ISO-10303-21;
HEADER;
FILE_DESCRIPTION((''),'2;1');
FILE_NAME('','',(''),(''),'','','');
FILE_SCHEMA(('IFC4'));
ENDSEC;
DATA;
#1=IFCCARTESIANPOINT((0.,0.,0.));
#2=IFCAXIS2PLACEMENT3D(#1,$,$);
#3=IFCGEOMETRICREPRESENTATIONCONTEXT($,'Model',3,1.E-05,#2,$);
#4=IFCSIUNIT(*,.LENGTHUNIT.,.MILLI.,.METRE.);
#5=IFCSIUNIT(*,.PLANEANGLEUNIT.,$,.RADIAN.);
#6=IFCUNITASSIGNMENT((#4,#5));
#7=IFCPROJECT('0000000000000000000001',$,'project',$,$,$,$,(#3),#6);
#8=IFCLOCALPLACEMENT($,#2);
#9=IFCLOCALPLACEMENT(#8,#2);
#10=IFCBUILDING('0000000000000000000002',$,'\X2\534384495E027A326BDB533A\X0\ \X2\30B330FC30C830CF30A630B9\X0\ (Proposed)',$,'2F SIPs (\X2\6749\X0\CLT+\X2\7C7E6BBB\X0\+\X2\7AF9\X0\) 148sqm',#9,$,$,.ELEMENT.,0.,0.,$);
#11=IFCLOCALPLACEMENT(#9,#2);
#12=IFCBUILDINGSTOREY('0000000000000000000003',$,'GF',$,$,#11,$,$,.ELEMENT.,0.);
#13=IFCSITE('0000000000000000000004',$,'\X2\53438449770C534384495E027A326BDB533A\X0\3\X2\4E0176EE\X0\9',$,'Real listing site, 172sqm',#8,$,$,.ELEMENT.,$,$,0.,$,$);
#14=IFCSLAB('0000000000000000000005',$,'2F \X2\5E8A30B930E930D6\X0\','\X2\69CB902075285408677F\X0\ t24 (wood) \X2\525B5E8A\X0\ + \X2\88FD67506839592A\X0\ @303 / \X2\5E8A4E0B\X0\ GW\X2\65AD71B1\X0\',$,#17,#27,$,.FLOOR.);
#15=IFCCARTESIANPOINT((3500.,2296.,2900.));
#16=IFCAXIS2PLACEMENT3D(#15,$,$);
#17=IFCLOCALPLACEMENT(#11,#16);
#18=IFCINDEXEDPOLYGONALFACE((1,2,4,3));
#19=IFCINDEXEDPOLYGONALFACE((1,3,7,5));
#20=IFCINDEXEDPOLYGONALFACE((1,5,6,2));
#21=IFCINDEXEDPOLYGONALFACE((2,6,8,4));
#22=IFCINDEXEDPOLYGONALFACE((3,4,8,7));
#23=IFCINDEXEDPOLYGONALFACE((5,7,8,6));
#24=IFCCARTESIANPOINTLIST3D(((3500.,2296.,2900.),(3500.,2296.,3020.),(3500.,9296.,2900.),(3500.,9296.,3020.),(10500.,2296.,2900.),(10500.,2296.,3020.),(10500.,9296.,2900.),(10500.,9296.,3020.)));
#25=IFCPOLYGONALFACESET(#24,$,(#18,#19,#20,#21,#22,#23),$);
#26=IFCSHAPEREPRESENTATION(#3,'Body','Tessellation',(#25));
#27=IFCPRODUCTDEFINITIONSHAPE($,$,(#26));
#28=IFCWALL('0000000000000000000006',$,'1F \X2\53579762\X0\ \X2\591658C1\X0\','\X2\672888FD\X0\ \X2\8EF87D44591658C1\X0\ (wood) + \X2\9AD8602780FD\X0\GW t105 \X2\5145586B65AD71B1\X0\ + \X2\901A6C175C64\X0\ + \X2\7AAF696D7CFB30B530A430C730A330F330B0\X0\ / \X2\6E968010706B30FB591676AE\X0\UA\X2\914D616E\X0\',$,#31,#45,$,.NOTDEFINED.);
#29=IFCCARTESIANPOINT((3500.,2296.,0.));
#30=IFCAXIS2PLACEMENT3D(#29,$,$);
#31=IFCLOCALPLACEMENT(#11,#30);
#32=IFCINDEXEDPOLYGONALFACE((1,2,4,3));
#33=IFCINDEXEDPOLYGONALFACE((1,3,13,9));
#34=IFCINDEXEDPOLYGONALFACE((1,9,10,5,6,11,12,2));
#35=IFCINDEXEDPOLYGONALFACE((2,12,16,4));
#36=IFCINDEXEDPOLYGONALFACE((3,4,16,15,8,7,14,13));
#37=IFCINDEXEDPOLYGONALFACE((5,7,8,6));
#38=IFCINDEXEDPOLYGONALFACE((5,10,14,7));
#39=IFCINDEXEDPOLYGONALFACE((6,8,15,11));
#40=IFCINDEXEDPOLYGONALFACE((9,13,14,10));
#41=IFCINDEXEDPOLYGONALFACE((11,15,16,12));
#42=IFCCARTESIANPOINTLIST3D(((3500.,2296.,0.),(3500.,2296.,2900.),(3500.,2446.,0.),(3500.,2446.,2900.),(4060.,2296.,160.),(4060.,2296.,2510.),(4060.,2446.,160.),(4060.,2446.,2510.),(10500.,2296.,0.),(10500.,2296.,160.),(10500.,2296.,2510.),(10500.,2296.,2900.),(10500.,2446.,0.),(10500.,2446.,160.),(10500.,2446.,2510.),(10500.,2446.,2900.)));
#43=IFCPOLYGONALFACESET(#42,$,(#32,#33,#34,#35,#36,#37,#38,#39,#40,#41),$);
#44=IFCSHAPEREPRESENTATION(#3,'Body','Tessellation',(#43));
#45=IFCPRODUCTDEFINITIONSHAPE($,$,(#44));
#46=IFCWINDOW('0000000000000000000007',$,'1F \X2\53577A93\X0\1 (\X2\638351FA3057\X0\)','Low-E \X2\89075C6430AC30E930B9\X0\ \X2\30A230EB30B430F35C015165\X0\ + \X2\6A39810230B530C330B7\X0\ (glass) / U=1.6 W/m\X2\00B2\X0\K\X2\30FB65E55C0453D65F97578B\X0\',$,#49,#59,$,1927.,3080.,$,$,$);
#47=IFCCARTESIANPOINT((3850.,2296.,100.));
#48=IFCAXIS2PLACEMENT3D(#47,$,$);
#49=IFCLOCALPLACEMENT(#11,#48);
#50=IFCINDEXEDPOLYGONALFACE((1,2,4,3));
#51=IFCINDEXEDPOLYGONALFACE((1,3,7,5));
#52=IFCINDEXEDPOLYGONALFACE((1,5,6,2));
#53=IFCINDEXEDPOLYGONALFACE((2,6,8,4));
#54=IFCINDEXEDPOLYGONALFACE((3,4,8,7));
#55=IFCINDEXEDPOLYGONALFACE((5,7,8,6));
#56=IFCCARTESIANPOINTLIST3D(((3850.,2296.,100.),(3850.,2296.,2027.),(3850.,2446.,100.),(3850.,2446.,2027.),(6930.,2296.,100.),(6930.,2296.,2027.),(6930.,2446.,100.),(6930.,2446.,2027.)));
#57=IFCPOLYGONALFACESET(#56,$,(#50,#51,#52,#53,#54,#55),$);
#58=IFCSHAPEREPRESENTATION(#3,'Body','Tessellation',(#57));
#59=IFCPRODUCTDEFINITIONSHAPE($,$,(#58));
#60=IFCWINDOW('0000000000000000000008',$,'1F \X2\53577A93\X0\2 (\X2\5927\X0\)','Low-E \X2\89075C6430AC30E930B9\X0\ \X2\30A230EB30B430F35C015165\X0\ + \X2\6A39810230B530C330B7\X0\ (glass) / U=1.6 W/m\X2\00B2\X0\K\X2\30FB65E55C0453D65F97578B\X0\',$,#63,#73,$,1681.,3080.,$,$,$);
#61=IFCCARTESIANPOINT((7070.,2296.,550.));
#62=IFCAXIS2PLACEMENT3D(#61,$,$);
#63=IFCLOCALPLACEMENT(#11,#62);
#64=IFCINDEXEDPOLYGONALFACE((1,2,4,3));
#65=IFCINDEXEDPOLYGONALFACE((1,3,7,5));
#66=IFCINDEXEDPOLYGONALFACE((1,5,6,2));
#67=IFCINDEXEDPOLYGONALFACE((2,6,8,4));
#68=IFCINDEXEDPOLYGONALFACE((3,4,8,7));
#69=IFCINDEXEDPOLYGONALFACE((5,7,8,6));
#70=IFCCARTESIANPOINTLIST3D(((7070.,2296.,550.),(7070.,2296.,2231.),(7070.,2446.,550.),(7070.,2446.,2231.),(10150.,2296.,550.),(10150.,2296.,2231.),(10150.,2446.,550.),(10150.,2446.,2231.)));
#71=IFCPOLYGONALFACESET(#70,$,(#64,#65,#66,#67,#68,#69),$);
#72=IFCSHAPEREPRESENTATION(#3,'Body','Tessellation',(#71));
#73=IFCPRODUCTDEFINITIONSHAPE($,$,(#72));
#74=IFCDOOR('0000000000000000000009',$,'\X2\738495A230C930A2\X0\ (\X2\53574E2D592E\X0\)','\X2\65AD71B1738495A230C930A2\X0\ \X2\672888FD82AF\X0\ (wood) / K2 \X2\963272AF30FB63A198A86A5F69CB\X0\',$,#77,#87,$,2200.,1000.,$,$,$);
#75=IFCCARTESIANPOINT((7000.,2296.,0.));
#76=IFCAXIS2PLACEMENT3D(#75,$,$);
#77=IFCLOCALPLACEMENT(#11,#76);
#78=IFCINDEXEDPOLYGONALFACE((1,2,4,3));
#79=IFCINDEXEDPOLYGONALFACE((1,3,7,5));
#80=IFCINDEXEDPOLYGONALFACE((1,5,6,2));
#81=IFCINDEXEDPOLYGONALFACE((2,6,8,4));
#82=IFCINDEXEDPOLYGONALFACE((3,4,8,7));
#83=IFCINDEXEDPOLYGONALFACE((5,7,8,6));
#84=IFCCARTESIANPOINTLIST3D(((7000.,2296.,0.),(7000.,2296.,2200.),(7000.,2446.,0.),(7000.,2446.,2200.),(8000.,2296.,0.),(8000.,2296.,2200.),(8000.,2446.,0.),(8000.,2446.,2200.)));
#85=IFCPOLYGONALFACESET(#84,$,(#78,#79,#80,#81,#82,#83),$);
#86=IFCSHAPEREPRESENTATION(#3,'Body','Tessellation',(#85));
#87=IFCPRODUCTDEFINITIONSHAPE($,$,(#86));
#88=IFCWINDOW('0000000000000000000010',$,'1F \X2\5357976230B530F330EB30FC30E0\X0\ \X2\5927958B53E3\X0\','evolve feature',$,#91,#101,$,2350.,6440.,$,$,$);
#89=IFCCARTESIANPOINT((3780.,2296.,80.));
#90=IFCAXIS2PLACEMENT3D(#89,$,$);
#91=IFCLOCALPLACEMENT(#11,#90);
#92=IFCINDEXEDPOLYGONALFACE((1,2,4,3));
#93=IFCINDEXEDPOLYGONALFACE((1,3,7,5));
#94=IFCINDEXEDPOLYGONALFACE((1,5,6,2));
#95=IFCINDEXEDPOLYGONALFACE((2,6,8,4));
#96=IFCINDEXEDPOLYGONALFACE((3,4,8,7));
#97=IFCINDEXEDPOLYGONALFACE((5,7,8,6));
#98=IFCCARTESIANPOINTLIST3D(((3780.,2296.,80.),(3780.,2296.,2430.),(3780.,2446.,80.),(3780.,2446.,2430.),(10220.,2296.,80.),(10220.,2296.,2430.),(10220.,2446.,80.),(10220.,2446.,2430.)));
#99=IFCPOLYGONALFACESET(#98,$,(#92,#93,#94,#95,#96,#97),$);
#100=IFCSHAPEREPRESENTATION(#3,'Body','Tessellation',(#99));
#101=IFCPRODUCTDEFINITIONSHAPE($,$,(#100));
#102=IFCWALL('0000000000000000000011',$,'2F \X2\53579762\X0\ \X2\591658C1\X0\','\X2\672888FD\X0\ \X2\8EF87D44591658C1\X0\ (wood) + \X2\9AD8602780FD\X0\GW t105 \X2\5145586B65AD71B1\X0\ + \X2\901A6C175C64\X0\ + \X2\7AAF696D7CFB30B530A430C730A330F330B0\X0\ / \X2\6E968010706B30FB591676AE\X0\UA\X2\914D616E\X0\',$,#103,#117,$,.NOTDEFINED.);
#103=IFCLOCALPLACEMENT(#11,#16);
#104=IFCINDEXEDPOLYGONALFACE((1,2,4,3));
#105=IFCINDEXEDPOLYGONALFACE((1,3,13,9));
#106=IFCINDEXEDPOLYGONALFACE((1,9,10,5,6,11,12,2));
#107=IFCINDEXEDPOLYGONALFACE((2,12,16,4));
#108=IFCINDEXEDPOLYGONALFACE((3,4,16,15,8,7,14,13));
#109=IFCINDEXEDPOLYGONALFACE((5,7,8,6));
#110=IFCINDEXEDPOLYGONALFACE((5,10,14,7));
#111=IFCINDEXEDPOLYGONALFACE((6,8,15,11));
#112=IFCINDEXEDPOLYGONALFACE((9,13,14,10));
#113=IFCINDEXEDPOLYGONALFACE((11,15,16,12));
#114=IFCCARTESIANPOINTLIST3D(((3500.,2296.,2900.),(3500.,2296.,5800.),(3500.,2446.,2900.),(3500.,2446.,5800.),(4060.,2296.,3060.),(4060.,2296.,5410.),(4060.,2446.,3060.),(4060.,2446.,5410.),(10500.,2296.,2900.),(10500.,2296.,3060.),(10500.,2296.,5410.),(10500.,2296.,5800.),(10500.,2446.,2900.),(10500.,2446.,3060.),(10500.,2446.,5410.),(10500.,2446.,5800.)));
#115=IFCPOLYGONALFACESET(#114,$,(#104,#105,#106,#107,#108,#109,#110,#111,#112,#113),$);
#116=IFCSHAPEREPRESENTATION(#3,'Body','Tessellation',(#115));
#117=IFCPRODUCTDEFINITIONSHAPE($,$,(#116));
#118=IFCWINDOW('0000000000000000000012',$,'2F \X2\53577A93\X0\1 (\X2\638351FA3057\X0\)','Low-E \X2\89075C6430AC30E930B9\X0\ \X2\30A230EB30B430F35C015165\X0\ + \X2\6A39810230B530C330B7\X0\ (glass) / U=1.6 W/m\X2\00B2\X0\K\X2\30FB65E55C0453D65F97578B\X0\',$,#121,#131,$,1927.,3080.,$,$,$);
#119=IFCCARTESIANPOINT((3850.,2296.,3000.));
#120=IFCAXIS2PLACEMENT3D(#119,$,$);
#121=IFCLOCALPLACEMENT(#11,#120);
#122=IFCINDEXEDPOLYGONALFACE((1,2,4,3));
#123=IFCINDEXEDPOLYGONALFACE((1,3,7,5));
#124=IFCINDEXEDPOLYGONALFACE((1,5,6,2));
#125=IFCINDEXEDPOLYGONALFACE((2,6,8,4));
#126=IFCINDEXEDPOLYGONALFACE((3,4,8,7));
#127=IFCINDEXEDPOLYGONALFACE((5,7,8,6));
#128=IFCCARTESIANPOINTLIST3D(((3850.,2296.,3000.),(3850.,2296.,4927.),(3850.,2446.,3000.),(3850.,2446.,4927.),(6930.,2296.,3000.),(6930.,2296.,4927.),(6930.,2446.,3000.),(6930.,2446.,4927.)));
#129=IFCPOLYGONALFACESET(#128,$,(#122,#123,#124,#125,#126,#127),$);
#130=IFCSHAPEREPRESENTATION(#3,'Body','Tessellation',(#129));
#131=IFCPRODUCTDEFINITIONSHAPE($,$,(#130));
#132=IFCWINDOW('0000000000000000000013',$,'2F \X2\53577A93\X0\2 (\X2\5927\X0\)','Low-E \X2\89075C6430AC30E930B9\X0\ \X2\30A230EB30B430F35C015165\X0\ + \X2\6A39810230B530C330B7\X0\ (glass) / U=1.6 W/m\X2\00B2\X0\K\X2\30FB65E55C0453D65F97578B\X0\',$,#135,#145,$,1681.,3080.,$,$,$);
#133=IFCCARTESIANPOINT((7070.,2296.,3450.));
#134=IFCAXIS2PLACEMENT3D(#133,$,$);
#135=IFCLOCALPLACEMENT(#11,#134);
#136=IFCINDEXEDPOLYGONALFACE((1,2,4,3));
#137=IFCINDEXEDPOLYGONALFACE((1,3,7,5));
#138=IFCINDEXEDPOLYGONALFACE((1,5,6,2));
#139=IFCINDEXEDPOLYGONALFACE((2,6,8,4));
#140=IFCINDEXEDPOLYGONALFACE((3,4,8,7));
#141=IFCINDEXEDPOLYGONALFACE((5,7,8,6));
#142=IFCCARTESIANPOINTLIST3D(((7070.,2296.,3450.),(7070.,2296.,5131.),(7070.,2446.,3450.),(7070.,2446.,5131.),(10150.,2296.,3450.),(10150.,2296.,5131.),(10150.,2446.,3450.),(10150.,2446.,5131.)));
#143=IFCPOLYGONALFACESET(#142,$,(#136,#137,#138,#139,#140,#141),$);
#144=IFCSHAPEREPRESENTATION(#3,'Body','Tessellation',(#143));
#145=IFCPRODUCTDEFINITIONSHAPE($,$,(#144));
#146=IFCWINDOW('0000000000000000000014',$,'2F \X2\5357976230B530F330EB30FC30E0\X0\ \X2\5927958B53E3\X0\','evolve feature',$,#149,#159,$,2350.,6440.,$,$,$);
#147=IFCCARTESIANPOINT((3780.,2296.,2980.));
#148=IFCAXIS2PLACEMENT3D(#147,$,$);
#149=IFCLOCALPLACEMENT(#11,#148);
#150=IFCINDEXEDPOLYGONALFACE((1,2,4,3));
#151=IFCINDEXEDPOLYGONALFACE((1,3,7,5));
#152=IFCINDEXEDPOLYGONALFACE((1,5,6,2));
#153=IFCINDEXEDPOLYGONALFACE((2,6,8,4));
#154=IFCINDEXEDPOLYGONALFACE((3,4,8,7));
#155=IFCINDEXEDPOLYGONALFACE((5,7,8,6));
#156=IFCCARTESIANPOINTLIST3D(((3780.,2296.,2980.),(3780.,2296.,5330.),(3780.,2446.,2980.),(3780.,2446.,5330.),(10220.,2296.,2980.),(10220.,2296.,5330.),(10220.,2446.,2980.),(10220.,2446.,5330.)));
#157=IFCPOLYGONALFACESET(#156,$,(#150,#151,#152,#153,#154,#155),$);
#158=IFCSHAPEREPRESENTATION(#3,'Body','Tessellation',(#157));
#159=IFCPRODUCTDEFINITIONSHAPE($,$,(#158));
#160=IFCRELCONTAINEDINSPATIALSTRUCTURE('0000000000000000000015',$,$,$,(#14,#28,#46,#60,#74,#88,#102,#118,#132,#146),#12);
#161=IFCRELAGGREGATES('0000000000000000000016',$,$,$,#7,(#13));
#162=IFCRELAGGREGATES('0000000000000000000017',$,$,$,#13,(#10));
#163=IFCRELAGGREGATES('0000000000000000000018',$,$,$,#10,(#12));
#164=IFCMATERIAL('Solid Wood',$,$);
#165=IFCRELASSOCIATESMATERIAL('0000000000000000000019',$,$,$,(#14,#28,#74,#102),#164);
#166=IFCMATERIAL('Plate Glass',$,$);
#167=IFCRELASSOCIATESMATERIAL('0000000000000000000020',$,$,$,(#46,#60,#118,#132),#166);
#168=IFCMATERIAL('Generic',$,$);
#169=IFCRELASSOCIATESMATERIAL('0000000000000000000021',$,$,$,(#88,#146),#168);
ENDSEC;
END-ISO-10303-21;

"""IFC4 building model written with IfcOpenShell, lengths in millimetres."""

from ifc_helpers import new_model, si_unit, frame, frame_2d, origin, place, context, project, spatial, rectangle, extrude, material, element, fill, save


model = new_model("IFC4")

# Units and contexts
model_context = context("Model", 3, precision=1e-05, world=origin())
ifc_project = project(units=[si_unit("LENGTHUNIT", "METRE", prefix="MILLI"), si_unit("PLANEANGLEUNIT", "RADIAN")], contexts=[model_context])

# Site, building, storey
site_placement = place(None, origin())
site = spatial("IfcSite", under=ifc_project, at=site_placement, Name="千葉県千葉市稲毛区3丁目9", ObjectType="Real listing site, 172sqm", CompositionType="ELEMENT", RefElevation=0.0)
building_placement = place(site_placement, origin())
building = spatial("IfcBuilding", under=site, at=building_placement, Name="千葉市稲毛区 コートハウス (Proposed)", ObjectType="2F SIPs (杉CLT+籾殻+竹) 148sqm", CompositionType="ELEMENT", ElevationOfRefHeight=0.0, ElevationOfTerrain=0.0)
storey_placement = place(building_placement, origin())
storey = spatial("IfcBuildingStorey", under=building, at=storey_placement, Name="GF", CompositionType="ELEMENT", Elevation=0.0)

# Slab
ifc_material_1 = material(Name="Solid Wood")
slab_1_placement = place(storey_placement, frame((3500.0, 2296.0, 2900.0)))
element("IfcSlab", 1, at=slab_1_placement, inside=storey, material=ifc_material_1, Name="2F 床スラブ", Description="構造用合板 t24 (wood) 剛床 + 製材根太 @303 / 床下 GW断熱", PredefinedType="FLOOR", context=model_context, shape_type="SweptSolid", body=[
    extrude(rectangle(XDim=7000.0, YDim=7000.0, at=frame_2d((3500.0, 3500.0))), frame((3500.0, 2296.0, 2900.0)), (0.0, 0.0, 1.0), 120.0),
])
ifc_material_2 = material(Name="Generic")

# Wall, openings, windows, door
wall_1_placement = place(storey_placement, frame((3500.0, 2296.0, 0.0)))
wall_1 = element("IfcWall", 2, at=wall_1_placement, inside=storey, material=ifc_material_1, Name="1F 南面 外壁", Description="木製 軸組外壁 (wood) + 高性能GW t105 充填断熱 + 通気層 + 窯業系サイディング / 準耐火・外皮UA配慮", PredefinedType="NOTDEFINED", context=model_context, shape_type="SweptSolid", body=[
    extrude(rectangle(XDim=7000.0, YDim=150.0, at=frame_2d((3500.0, 75.0))), frame((3500.0, 2296.0, 0.0)), (0.0, 0.0, 1.0), 2900.0),
])
opening_1_placement = place(storey_placement, frame((3850.0, 2296.0, 100.0)))
opening_1 = element("IfcOpeningElement", 3, at=opening_1_placement, cuts=wall_1, PredefinedType="NOTDEFINED", context=model_context, shape_type="SweptSolid", body=[
    extrude(rectangle(XDim=3080.0, YDim=150.0, at=frame_2d((1540.0, 75.0))), frame((3850.0, 2296.0, 100.0)), (0.0, 0.0, 1.0), 1927.0),
])
opening_2_placement = place(storey_placement, frame((7070.0, 2296.0, 550.0)))
opening_2 = element("IfcOpeningElement", 4, at=opening_2_placement, cuts=wall_1, PredefinedType="NOTDEFINED", context=model_context, shape_type="SweptSolid", body=[
    extrude(rectangle(XDim=3080.0, YDim=150.0, at=frame_2d((1540.0, 75.0))), frame((7070.0, 2296.0, 550.0)), (0.0, 0.0, 1.0), 1681.0),
])
opening_3_placement = place(storey_placement, frame((7000.0, 2296.0, 0.0)))
opening_3 = element("IfcOpeningElement", 5, at=opening_3_placement, cuts=wall_1, PredefinedType="NOTDEFINED", context=model_context, shape_type="SweptSolid", body=[
    extrude(rectangle(XDim=1000.0, YDim=150.0, at=frame_2d((500.0, 75.0))), frame((7000.0, 2296.0, 0.0)), (0.0, 0.0, 1.0), 2200.0),
])
opening_4_placement = place(storey_placement, frame((3780.0, 2296.0, 80.0)))
opening_4 = element("IfcOpeningElement", 6, at=opening_4_placement, cuts=wall_1, PredefinedType="NOTDEFINED", context=model_context, shape_type="SweptSolid", body=[
    extrude(rectangle(XDim=6440.0, YDim=150.0, at=frame_2d((3220.0, 75.0))), frame((3780.0, 2296.0, 80.0)), (0.0, 0.0, 1.0), 2350.0),
])
ifc_material_3 = material(Name="Plate Glass")
window_1_placement = place(storey_placement, frame((3850.0, 2296.0, 100.0)))
window_1 = element("IfcWindow", 7, at=window_1_placement, inside=storey, material=ifc_material_3, Name="1F 南窓1 (掃出し)", Description="Low-E 複層ガラス アルゴン封入 + 樹脂サッシ (glass) / U=1.6 W/m²K・日射取得型", OverallHeight=1927.0, OverallWidth=3080.0, context=model_context, shape_type="SweptSolid", body=[
    extrude(rectangle(XDim=3080.0, YDim=150.0, at=frame_2d((1540.0, 75.0))), frame((3850.0, 2296.0, 100.0)), (0.0, 0.0, 1.0), 1927.0),
])
fill(opening_1, window_1)
window_2_placement = place(storey_placement, frame((7070.0, 2296.0, 550.0)))
window_2 = element("IfcWindow", 8, at=window_2_placement, inside=storey, material=ifc_material_3, Name="1F 南窓2 (大)", Description="Low-E 複層ガラス アルゴン封入 + 樹脂サッシ (glass) / U=1.6 W/m²K・日射取得型", OverallHeight=1681.0, OverallWidth=3080.0, context=model_context, shape_type="SweptSolid", body=[
    extrude(rectangle(XDim=3080.0, YDim=150.0, at=frame_2d((1540.0, 75.0))), frame((7070.0, 2296.0, 550.0)), (0.0, 0.0, 1.0), 1681.0),
])
fill(opening_2, window_2)
door_placement = place(storey_placement, frame((7000.0, 2296.0, 0.0)))
door = element("IfcDoor", 9, at=door_placement, inside=storey, material=ifc_material_1, Name="玄関ドア (南中央)", Description="断熱玄関ドア 木製芯 (wood) / K2 防犯・採風機構", OverallHeight=2200.0, OverallWidth=1000.0, context=model_context, shape_type="SweptSolid", body=[
    extrude(rectangle(XDim=1000.0, YDim=150.0, at=frame_2d((500.0, 75.0))), frame((7000.0, 2296.0, 0.0)), (0.0, 0.0, 1.0), 2200.0),
])
fill(opening_3, door)
window_3_placement = place(storey_placement, frame((3780.0, 2296.0, 80.0)))
window_3 = element("IfcWindow", 10, at=window_3_placement, inside=storey, material=ifc_material_2, Name="1F 南面サンルーム 大開口", Description="evolve feature", OverallHeight=2350.0, OverallWidth=6440.0, context=model_context, shape_type="SweptSolid", body=[
    extrude(rectangle(XDim=6440.0, YDim=150.0, at=frame_2d((3220.0, 75.0))), frame((3780.0, 2296.0, 80.0)), (0.0, 0.0, 1.0), 2350.0),
])
fill(opening_4, window_3)

# Wall, openings, windows
wall_2_placement = place(storey_placement, frame((3500.0, 2296.0, 2900.0)))
wall_2 = element("IfcWall", 11, at=wall_2_placement, inside=storey, material=ifc_material_1, Name="2F 南面 外壁", Description="木製 軸組外壁 (wood) + 高性能GW t105 充填断熱 + 通気層 + 窯業系サイディング / 準耐火・外皮UA配慮", PredefinedType="NOTDEFINED", context=model_context, shape_type="SweptSolid", body=[
    extrude(rectangle(XDim=7000.0, YDim=150.0, at=frame_2d((3500.0, 75.0))), frame((3500.0, 2296.0, 2900.0)), (0.0, 0.0, 1.0), 2900.0),
])
opening_5_placement = place(storey_placement, frame((3850.0, 2296.0, 3000.0)))
opening_5 = element("IfcOpeningElement", 12, at=opening_5_placement, cuts=wall_2, PredefinedType="NOTDEFINED", context=model_context, shape_type="SweptSolid", body=[
    extrude(rectangle(XDim=3080.0, YDim=150.0, at=frame_2d((1540.0, 75.0))), frame((3850.0, 2296.0, 3000.0)), (0.0, 0.0, 1.0), 1927.0),
])
opening_6_placement = place(storey_placement, frame((7070.0, 2296.0, 3450.0)))
opening_6 = element("IfcOpeningElement", 13, at=opening_6_placement, cuts=wall_2, PredefinedType="NOTDEFINED", context=model_context, shape_type="SweptSolid", body=[
    extrude(rectangle(XDim=3080.0, YDim=150.0, at=frame_2d((1540.0, 75.0))), frame((7070.0, 2296.0, 3450.0)), (0.0, 0.0, 1.0), 1681.0),
])
opening_7_placement = place(storey_placement, frame((3780.0, 2296.0, 2980.0)))
opening_7 = element("IfcOpeningElement", 14, at=opening_7_placement, cuts=wall_2, PredefinedType="NOTDEFINED", context=model_context, shape_type="SweptSolid", body=[
    extrude(rectangle(XDim=6440.0, YDim=150.0, at=frame_2d((3220.0, 75.0))), frame((3780.0, 2296.0, 2980.0)), (0.0, 0.0, 1.0), 2350.0),
])
window_4_placement = place(storey_placement, frame((3850.0, 2296.0, 3000.0)))
window_4 = element("IfcWindow", 15, at=window_4_placement, inside=storey, material=ifc_material_3, Name="2F 南窓1 (掃出し)", Description="Low-E 複層ガラス アルゴン封入 + 樹脂サッシ (glass) / U=1.6 W/m²K・日射取得型", OverallHeight=1927.0, OverallWidth=3080.0, context=model_context, shape_type="SweptSolid", body=[
    extrude(rectangle(XDim=3080.0, YDim=150.0, at=frame_2d((1540.0, 75.0))), frame((3850.0, 2296.0, 3000.0)), (0.0, 0.0, 1.0), 1927.0),
])
fill(opening_5, window_4)
window_5_placement = place(storey_placement, frame((7070.0, 2296.0, 3450.0)))
window_5 = element("IfcWindow", 16, at=window_5_placement, inside=storey, material=ifc_material_3, Name="2F 南窓2 (大)", Description="Low-E 複層ガラス アルゴン封入 + 樹脂サッシ (glass) / U=1.6 W/m²K・日射取得型", OverallHeight=1681.0, OverallWidth=3080.0, context=model_context, shape_type="SweptSolid", body=[
    extrude(rectangle(XDim=3080.0, YDim=150.0, at=frame_2d((1540.0, 75.0))), frame((7070.0, 2296.0, 3450.0)), (0.0, 0.0, 1.0), 1681.0),
])
fill(opening_6, window_5)
window_6_placement = place(storey_placement, frame((3780.0, 2296.0, 2980.0)))
window_6 = element("IfcWindow", 17, at=window_6_placement, inside=storey, material=ifc_material_2, Name="2F 南面サンルーム 大開口", Description="evolve feature", OverallHeight=2350.0, OverallWidth=6440.0, context=model_context, shape_type="SweptSolid", body=[
    extrude(rectangle(XDim=6440.0, YDim=150.0, at=frame_2d((3220.0, 75.0))), frame((3780.0, 2296.0, 2980.0)), (0.0, 0.0, 1.0), 2350.0),
])
fill(opening_7, window_6)

save(model, "model.ifc")
